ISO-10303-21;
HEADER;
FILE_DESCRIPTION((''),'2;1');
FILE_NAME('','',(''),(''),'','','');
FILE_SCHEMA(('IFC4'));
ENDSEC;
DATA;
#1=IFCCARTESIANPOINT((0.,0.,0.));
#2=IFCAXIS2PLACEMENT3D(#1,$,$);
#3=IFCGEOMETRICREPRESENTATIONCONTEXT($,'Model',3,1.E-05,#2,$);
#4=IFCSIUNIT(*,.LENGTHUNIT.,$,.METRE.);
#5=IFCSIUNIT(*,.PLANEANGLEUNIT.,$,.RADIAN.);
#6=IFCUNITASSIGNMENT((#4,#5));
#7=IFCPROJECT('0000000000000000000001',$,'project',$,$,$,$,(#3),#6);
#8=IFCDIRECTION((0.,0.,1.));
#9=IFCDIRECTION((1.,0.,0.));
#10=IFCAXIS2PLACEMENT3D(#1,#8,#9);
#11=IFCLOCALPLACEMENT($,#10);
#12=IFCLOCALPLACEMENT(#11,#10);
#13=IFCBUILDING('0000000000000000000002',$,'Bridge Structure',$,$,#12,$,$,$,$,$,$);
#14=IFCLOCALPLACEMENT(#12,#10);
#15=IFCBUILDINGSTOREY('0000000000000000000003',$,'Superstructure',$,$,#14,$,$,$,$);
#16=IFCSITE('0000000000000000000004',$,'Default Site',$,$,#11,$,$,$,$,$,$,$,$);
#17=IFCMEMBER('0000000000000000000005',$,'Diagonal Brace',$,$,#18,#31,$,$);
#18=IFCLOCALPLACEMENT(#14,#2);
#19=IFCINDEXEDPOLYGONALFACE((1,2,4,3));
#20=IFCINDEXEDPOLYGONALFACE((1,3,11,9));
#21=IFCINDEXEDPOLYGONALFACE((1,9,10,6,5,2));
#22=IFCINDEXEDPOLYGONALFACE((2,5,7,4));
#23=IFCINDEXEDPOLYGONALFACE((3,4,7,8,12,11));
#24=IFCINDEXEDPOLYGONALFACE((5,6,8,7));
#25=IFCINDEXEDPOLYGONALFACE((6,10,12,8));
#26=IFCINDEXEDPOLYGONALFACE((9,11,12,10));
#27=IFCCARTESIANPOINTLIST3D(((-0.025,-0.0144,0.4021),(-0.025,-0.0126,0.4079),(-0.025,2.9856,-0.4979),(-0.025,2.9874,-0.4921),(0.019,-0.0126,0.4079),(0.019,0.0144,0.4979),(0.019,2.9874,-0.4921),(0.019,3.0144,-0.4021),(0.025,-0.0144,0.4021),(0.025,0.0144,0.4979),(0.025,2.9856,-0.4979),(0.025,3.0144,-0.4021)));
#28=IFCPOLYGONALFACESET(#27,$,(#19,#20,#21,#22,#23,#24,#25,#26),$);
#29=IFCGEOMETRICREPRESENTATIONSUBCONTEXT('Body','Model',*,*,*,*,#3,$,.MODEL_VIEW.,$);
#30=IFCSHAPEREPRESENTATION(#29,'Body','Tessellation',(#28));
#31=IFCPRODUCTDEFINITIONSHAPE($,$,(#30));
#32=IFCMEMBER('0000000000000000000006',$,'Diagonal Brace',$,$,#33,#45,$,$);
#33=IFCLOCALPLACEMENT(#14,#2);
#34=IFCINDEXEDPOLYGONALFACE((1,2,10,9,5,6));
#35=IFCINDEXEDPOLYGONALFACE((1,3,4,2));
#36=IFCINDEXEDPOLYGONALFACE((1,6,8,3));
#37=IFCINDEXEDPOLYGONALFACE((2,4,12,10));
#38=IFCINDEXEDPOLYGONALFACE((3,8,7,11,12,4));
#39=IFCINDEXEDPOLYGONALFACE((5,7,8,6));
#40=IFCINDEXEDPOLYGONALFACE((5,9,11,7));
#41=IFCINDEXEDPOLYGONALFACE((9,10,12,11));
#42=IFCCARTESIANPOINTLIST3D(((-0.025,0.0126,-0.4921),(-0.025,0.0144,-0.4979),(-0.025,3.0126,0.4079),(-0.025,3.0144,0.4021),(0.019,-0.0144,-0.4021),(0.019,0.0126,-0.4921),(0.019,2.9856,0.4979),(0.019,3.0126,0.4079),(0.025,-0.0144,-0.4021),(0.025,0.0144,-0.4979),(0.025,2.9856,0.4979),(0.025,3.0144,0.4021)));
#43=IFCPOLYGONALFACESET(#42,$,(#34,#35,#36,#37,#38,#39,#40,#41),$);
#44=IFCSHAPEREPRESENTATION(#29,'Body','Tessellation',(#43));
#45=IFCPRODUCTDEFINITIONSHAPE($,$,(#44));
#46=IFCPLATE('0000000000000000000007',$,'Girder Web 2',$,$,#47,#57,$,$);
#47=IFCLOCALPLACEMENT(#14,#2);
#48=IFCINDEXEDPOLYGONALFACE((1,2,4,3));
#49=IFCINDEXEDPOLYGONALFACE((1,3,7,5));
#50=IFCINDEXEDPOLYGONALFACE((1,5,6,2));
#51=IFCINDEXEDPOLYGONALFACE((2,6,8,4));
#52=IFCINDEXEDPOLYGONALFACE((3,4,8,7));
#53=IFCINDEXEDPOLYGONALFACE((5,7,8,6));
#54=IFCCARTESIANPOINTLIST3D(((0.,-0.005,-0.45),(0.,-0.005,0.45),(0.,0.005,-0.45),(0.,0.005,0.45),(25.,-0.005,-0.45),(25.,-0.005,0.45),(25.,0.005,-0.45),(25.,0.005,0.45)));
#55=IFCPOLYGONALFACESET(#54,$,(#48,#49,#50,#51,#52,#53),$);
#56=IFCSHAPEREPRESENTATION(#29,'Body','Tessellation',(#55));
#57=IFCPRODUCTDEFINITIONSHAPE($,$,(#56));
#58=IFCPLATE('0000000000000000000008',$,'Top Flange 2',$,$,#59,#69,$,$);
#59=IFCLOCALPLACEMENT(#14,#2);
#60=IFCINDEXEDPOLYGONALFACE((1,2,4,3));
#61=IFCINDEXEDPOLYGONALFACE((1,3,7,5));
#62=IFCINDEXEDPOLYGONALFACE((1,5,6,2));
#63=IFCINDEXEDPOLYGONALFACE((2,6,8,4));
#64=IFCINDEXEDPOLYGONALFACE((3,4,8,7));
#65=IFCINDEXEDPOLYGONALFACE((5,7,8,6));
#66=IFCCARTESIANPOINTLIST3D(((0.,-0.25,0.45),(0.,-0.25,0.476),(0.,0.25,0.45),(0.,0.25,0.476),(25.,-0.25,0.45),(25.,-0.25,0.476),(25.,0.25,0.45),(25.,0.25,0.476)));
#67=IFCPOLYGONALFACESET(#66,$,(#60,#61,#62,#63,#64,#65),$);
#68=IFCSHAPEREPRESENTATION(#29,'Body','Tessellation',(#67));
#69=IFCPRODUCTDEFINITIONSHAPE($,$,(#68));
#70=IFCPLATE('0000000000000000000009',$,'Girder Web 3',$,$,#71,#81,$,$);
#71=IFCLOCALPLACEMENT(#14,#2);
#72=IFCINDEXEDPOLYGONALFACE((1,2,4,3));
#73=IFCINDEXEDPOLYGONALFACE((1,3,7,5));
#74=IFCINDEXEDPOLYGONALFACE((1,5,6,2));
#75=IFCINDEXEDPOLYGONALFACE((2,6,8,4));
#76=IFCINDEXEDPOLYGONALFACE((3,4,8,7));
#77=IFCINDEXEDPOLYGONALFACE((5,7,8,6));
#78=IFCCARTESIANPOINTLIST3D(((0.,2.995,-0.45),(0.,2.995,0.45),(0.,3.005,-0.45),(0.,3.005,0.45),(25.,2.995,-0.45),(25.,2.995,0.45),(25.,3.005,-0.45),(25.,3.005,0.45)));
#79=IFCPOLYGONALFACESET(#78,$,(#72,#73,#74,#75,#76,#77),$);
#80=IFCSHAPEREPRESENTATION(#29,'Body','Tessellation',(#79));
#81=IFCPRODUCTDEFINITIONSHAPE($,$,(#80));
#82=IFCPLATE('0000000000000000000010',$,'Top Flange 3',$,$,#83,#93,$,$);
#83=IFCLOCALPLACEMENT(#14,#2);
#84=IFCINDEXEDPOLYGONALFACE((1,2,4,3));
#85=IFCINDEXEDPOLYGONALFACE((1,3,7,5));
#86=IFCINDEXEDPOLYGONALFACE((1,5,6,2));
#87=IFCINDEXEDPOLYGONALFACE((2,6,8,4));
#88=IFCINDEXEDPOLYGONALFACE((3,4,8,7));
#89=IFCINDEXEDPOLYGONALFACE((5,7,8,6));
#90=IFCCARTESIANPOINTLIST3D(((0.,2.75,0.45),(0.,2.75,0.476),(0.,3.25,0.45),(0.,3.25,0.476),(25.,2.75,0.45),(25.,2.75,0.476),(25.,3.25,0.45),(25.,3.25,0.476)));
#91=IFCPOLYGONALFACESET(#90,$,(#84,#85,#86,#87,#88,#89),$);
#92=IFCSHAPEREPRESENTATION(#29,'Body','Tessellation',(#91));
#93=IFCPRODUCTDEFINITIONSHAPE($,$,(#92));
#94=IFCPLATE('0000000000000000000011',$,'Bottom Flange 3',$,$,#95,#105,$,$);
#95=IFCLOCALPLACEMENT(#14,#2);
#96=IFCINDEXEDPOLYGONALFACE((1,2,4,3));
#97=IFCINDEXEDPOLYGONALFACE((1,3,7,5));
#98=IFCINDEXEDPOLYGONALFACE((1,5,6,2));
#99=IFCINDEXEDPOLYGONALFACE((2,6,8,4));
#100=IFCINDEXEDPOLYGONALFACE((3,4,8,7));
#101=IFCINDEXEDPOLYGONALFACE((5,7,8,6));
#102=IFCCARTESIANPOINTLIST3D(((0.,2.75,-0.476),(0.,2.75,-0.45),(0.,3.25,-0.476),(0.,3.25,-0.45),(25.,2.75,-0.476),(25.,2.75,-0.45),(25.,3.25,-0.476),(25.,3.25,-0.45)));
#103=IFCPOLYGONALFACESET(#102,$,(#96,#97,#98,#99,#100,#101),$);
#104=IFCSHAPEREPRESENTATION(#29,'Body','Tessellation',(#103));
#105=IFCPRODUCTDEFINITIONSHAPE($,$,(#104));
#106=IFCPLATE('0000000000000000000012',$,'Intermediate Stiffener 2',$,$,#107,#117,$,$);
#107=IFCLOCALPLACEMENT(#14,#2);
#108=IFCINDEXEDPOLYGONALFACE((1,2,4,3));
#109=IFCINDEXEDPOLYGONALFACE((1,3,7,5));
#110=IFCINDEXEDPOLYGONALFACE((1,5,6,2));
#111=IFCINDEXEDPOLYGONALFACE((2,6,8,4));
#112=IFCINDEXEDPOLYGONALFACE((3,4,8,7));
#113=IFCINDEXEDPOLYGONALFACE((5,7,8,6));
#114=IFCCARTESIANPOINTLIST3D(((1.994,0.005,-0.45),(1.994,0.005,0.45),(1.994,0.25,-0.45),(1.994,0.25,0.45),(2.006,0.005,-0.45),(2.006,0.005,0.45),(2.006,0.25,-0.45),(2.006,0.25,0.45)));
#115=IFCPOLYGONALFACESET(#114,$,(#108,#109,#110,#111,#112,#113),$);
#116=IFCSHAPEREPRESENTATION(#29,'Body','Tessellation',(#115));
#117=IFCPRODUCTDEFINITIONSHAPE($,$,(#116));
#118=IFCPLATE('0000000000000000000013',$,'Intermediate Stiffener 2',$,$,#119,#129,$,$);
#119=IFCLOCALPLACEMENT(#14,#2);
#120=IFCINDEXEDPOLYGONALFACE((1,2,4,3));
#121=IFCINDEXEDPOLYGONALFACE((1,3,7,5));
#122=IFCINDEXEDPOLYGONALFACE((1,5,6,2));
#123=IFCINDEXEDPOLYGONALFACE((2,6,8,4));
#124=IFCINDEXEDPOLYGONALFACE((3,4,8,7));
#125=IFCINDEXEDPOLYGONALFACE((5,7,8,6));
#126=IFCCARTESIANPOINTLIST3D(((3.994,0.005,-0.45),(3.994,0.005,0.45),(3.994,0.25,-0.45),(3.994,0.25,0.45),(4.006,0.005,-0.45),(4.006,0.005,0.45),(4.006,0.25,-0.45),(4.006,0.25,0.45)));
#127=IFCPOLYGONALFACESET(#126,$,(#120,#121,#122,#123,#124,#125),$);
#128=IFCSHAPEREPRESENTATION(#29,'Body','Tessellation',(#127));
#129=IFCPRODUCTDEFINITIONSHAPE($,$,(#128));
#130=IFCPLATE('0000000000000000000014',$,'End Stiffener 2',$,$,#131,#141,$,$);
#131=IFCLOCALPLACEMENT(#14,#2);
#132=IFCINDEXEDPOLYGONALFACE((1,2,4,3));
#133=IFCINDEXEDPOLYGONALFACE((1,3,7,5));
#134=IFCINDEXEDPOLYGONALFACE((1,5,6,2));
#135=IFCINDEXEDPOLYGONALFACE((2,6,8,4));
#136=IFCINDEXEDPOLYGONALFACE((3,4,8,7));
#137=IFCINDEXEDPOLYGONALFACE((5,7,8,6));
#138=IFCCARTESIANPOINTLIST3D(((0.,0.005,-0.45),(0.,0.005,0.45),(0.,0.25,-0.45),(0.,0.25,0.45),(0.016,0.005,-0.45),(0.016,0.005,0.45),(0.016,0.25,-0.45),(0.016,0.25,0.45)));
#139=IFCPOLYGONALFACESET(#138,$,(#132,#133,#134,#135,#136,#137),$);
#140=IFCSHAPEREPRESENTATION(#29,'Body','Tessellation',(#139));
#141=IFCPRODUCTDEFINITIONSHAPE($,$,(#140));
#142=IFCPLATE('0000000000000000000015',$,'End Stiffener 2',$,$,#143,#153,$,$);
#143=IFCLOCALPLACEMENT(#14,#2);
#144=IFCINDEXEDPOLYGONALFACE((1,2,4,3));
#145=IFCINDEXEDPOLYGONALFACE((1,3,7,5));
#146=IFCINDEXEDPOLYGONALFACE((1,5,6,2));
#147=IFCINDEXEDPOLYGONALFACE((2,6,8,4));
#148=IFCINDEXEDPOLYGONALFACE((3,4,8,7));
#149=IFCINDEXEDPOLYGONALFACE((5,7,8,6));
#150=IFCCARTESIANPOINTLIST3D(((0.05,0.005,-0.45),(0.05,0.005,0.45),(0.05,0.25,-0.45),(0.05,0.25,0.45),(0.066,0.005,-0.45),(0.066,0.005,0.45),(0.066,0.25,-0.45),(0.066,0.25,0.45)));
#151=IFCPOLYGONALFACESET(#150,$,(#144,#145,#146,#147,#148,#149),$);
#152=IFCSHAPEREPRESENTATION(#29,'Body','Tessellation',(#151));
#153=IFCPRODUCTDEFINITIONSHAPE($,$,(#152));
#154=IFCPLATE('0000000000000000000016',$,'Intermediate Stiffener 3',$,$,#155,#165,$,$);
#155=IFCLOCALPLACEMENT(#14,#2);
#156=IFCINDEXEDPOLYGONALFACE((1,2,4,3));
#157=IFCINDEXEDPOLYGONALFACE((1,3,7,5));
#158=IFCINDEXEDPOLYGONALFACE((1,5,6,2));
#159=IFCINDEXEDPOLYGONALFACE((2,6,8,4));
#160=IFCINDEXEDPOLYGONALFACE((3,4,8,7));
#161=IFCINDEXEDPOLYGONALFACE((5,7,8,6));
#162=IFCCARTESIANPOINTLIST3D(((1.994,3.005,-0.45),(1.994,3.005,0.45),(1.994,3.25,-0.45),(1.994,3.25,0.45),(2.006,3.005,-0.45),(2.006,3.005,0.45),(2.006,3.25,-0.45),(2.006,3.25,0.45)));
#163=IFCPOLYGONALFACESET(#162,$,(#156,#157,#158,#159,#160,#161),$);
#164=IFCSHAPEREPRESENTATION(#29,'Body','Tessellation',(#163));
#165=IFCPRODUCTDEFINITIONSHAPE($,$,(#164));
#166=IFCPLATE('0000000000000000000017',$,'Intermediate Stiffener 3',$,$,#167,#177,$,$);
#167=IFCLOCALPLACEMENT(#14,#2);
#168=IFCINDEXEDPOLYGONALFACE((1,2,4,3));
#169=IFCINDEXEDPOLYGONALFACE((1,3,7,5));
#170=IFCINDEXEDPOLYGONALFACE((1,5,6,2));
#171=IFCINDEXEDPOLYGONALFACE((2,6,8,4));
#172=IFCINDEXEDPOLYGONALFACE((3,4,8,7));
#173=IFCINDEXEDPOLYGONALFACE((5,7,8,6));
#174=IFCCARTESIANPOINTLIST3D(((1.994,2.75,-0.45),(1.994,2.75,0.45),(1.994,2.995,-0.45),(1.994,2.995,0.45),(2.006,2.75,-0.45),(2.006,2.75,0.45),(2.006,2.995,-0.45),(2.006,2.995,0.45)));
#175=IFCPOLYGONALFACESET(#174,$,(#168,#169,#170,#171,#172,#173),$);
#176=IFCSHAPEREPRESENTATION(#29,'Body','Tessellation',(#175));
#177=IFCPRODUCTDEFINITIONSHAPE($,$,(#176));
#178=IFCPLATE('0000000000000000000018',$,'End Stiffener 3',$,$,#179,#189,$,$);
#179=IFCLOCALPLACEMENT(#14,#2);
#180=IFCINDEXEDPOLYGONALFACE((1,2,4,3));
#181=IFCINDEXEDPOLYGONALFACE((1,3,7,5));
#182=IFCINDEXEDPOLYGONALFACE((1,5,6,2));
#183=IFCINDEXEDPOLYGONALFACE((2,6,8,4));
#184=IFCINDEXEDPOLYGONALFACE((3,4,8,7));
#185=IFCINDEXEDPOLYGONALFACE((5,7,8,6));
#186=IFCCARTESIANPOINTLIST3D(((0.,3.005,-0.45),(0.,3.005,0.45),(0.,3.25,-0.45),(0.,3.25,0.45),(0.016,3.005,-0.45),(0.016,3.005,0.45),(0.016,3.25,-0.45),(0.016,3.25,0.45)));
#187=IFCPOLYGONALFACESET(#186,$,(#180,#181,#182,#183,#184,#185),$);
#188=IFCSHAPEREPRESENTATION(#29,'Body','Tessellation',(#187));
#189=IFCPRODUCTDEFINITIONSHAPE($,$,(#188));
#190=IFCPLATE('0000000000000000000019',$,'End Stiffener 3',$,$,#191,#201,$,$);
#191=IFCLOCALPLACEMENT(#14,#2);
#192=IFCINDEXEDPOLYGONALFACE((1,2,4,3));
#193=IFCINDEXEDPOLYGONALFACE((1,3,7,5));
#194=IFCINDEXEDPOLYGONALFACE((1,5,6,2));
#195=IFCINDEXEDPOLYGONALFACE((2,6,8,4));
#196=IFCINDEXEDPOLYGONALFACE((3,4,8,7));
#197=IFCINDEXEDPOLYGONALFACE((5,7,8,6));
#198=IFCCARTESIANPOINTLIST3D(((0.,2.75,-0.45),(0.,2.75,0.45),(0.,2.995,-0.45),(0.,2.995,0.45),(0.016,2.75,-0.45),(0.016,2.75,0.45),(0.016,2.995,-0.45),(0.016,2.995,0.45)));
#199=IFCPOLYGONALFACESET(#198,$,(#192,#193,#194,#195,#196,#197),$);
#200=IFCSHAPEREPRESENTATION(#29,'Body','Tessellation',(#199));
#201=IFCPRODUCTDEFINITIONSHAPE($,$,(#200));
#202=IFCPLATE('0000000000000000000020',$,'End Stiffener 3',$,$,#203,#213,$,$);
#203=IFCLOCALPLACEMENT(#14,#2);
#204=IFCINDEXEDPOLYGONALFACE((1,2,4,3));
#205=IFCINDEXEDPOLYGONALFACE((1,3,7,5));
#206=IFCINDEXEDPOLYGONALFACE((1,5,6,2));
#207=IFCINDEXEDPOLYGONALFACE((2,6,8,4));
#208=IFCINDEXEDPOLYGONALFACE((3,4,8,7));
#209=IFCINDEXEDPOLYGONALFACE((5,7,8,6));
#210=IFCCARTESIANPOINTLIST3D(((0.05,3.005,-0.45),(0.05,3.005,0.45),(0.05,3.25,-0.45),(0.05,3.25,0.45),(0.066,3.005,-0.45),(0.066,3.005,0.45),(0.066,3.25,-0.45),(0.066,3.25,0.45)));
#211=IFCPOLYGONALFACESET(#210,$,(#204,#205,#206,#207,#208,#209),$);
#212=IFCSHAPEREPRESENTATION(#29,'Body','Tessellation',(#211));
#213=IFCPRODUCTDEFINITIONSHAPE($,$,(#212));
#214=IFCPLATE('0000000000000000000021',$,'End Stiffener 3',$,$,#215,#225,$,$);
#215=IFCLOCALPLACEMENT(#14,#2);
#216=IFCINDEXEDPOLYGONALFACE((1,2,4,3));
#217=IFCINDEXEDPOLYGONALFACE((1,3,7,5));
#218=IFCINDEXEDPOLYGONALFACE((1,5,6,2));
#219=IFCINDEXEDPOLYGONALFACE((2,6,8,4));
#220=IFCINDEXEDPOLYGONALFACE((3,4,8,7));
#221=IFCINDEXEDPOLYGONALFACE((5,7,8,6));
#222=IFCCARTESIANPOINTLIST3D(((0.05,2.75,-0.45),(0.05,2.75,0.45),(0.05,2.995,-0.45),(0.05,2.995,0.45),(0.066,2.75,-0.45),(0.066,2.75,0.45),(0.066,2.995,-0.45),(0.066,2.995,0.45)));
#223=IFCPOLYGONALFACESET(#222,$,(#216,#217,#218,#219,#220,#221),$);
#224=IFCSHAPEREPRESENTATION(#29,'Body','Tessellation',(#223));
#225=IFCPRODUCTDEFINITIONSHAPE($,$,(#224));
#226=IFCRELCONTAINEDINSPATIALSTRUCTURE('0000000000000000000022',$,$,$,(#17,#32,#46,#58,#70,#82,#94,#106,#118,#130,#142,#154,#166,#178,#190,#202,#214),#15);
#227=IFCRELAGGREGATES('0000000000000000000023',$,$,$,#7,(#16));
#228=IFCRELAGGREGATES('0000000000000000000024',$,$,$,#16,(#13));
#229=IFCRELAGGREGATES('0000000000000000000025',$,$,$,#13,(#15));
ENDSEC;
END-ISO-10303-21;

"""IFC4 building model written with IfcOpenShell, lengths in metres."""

from ifc_helpers import new_model, si_unit, frame, origin, origin_with_axes, origin_2d_with_axis, place, context, subcontext, project, spatial, rectangle, l_section, extrude, element, save


model = new_model("IFC4")

# Units and contexts
model_context = context("Model", 3, precision=1e-05, world=origin())
body_context = subcontext(model_context, "Body", "Model", "MODEL_VIEW")
ifc_project = project(units=[si_unit("LENGTHUNIT", "METRE"), si_unit("PLANEANGLEUNIT", "RADIAN")], contexts=[model_context])

# Site, building, storey
site_placement = place(None, origin_with_axes())
site = spatial("IfcSite", under=ifc_project, at=site_placement, Name="Default Site")
building_placement = place(site_placement, origin_with_axes())
building = spatial("IfcBuilding", under=site, at=building_placement, Name="Bridge Structure")
storey_placement = place(building_placement, origin_with_axes())
storey = spatial("IfcBuildingStorey", under=building, at=storey_placement, Name="Superstructure")

# Members
for number, where, z_axis, x_axis, name in (
    (1, (0.0, 0.0, 0.45), (0.0, 0.957826, -0.287348), (-1.0, 0.0, 0.0), "Diagonal Brace"),
    (2, (0.0, 0.0, -0.45), (0.0, 0.957826, 0.287348), (-1.0, 0.0, 0.0), "Diagonal Brace"),
):
    element("IfcMember", number, at=place(storey_placement, frame(where, z_axis=z_axis, x_axis=x_axis)), inside=storey, Name=name, context=body_context, shape_type="SweptSolid", body=[
        extrude(l_section(Depth=0.1, Width=0.05, Thickness=0.006, at=origin_2d_with_axis()), origin_with_axes(), (0.0, 0.0, 1.0), 3.1321),
    ])

# Plates
plate_1_placement = place(storey_placement, frame((0.0, 0.0, 0.0), z_axis=(1.0, 0.0, 0.0), x_axis=(0.0, 1.0, 0.0)))
element("IfcPlate", 3, at=plate_1_placement, inside=storey, Name="Girder Web 2", context=body_context, shape_type="SweptSolid", body=[
    extrude(rectangle(XDim=0.01, YDim=0.9, at=origin_2d_with_axis()), origin_with_axes(), (0.0, 0.0, 1.0), 25.0),
])
plate_2_placement = place(storey_placement, frame((0.0, 0.0, 0.463), z_axis=(1.0, 0.0, 0.0), x_axis=(0.0, 1.0, 0.0)))
element("IfcPlate", 4, at=plate_2_placement, inside=storey, Name="Top Flange 2", context=body_context, shape_type="SweptSolid", body=[
    extrude(rectangle(XDim=0.5, YDim=0.026, at=origin_2d_with_axis()), origin_with_axes(), (0.0, 0.0, 1.0), 25.0),
])
plate_3_placement = place(storey_placement, frame((0.0, 3.0, 0.0), z_axis=(1.0, 0.0, 0.0), x_axis=(0.0, 1.0, 0.0)))
element("IfcPlate", 5, at=plate_3_placement, inside=storey, Name="Girder Web 3", context=body_context, shape_type="SweptSolid", body=[
    extrude(rectangle(XDim=0.01, YDim=0.9, at=origin_2d_with_axis()), origin_with_axes(), (0.0, 0.0, 1.0), 25.0),
])
for number, where, z_axis, x_axis, name in (
    (6, (0.0, 3.0, 0.463), (1.0, 0.0, 0.0), (0.0, 1.0, 0.0), "Top Flange 3"),
    (7, (0.0, 3.0, -0.463), (1.0, 0.0, 0.0), (0.0, 1.0, 0.0), "Bottom Flange 3"),
):
    element("IfcPlate", number, at=place(storey_placement, frame(where, z_axis=z_axis, x_axis=x_axis)), inside=storey, Name=name, context=body_context, shape_type="SweptSolid", body=[
        extrude(rectangle(XDim=0.5, YDim=0.026, at=origin_2d_with_axis()), origin_with_axes(), (0.0, 0.0, 1.0), 25.0),
    ])
for number, where, z_axis, x_axis, name in (
    (8, (2.0, 0.1275, -0.45), (0.0, 0.0, 1.0), (1.0, 0.0, 0.0), "Intermediate Stiffener 2"),
    (9, (4.0, 0.1275, -0.45), (0.0, 0.0, 1.0), (1.0, 0.0, 0.0), "Intermediate Stiffener 2"),
):
    element("IfcPlate", number, at=place(storey_placement, frame(where, z_axis=z_axis, x_axis=x_axis)), inside=storey, Name=name, context=body_context, shape_type="SweptSolid", body=[
        extrude(rectangle(XDim=0.012, YDim=0.245, at=origin_2d_with_axis()), origin_with_axes(), (0.0, 0.0, 1.0), 0.9),
    ])
for number, where, z_axis, x_axis, name in (
    (10, (0.008, 0.1275, -0.45), (0.0, 0.0, 1.0), (1.0, 0.0, 0.0), "End Stiffener 2"),
    (11, (0.058, 0.1275, -0.45), (0.0, 0.0, 1.0), (1.0, 0.0, 0.0), "End Stiffener 2"),
):
    element("IfcPlate", number, at=place(storey_placement, frame(where, z_axis=z_axis, x_axis=x_axis)), inside=storey, Name=name, context=body_context, shape_type="SweptSolid", body=[
        extrude(rectangle(XDim=0.016, YDim=0.245, at=origin_2d_with_axis()), origin_with_axes(), (0.0, 0.0, 1.0), 0.9),
    ])
for number, where, z_axis, x_axis, name in (
    (12, (2.0, 3.1275, -0.45), (0.0, 0.0, 1.0), (1.0, 0.0, 0.0), "Intermediate Stiffener 3"),
    (13, (2.0, 2.8725, -0.45), (0.0, 0.0, 1.0), (1.0, 0.0, 0.0), "Intermediate Stiffener 3"),
):
    element("IfcPlate", number, at=place(storey_placement, frame(where, z_axis=z_axis, x_axis=x_axis)), inside=storey, Name=name, context=body_context, shape_type="SweptSolid", body=[
        extrude(rectangle(XDim=0.012, YDim=0.245, at=origin_2d_with_axis()), origin_with_axes(), (0.0, 0.0, 1.0), 0.9),
    ])
for number, where, z_axis, x_axis, name in (
    (14, (0.008, 3.1275, -0.45), (0.0, 0.0, 1.0), (1.0, 0.0, 0.0), "End Stiffener 3"),
    (15, (0.008, 2.8725, -0.45), (0.0, 0.0, 1.0), (1.0, 0.0, 0.0), "End Stiffener 3"),
    (16, (0.058, 3.1275, -0.45), (0.0, 0.0, 1.0), (1.0, 0.0, 0.0), "End Stiffener 3"),
    (17, (0.058, 2.8725, -0.45), (0.0, 0.0, 1.0), (1.0, 0.0, 0.0), "End Stiffener 3"),
):
    element("IfcPlate", number, at=place(storey_placement, frame(where, z_axis=z_axis, x_axis=x_axis)), inside=storey, Name=name, context=body_context, shape_type="SweptSolid", body=[
        extrude(rectangle(XDim=0.016, YDim=0.245, at=origin_2d_with_axis()), origin_with_axes(), (0.0, 0.0, 1.0), 0.9),
    ])

save(model, "model.ifc")
